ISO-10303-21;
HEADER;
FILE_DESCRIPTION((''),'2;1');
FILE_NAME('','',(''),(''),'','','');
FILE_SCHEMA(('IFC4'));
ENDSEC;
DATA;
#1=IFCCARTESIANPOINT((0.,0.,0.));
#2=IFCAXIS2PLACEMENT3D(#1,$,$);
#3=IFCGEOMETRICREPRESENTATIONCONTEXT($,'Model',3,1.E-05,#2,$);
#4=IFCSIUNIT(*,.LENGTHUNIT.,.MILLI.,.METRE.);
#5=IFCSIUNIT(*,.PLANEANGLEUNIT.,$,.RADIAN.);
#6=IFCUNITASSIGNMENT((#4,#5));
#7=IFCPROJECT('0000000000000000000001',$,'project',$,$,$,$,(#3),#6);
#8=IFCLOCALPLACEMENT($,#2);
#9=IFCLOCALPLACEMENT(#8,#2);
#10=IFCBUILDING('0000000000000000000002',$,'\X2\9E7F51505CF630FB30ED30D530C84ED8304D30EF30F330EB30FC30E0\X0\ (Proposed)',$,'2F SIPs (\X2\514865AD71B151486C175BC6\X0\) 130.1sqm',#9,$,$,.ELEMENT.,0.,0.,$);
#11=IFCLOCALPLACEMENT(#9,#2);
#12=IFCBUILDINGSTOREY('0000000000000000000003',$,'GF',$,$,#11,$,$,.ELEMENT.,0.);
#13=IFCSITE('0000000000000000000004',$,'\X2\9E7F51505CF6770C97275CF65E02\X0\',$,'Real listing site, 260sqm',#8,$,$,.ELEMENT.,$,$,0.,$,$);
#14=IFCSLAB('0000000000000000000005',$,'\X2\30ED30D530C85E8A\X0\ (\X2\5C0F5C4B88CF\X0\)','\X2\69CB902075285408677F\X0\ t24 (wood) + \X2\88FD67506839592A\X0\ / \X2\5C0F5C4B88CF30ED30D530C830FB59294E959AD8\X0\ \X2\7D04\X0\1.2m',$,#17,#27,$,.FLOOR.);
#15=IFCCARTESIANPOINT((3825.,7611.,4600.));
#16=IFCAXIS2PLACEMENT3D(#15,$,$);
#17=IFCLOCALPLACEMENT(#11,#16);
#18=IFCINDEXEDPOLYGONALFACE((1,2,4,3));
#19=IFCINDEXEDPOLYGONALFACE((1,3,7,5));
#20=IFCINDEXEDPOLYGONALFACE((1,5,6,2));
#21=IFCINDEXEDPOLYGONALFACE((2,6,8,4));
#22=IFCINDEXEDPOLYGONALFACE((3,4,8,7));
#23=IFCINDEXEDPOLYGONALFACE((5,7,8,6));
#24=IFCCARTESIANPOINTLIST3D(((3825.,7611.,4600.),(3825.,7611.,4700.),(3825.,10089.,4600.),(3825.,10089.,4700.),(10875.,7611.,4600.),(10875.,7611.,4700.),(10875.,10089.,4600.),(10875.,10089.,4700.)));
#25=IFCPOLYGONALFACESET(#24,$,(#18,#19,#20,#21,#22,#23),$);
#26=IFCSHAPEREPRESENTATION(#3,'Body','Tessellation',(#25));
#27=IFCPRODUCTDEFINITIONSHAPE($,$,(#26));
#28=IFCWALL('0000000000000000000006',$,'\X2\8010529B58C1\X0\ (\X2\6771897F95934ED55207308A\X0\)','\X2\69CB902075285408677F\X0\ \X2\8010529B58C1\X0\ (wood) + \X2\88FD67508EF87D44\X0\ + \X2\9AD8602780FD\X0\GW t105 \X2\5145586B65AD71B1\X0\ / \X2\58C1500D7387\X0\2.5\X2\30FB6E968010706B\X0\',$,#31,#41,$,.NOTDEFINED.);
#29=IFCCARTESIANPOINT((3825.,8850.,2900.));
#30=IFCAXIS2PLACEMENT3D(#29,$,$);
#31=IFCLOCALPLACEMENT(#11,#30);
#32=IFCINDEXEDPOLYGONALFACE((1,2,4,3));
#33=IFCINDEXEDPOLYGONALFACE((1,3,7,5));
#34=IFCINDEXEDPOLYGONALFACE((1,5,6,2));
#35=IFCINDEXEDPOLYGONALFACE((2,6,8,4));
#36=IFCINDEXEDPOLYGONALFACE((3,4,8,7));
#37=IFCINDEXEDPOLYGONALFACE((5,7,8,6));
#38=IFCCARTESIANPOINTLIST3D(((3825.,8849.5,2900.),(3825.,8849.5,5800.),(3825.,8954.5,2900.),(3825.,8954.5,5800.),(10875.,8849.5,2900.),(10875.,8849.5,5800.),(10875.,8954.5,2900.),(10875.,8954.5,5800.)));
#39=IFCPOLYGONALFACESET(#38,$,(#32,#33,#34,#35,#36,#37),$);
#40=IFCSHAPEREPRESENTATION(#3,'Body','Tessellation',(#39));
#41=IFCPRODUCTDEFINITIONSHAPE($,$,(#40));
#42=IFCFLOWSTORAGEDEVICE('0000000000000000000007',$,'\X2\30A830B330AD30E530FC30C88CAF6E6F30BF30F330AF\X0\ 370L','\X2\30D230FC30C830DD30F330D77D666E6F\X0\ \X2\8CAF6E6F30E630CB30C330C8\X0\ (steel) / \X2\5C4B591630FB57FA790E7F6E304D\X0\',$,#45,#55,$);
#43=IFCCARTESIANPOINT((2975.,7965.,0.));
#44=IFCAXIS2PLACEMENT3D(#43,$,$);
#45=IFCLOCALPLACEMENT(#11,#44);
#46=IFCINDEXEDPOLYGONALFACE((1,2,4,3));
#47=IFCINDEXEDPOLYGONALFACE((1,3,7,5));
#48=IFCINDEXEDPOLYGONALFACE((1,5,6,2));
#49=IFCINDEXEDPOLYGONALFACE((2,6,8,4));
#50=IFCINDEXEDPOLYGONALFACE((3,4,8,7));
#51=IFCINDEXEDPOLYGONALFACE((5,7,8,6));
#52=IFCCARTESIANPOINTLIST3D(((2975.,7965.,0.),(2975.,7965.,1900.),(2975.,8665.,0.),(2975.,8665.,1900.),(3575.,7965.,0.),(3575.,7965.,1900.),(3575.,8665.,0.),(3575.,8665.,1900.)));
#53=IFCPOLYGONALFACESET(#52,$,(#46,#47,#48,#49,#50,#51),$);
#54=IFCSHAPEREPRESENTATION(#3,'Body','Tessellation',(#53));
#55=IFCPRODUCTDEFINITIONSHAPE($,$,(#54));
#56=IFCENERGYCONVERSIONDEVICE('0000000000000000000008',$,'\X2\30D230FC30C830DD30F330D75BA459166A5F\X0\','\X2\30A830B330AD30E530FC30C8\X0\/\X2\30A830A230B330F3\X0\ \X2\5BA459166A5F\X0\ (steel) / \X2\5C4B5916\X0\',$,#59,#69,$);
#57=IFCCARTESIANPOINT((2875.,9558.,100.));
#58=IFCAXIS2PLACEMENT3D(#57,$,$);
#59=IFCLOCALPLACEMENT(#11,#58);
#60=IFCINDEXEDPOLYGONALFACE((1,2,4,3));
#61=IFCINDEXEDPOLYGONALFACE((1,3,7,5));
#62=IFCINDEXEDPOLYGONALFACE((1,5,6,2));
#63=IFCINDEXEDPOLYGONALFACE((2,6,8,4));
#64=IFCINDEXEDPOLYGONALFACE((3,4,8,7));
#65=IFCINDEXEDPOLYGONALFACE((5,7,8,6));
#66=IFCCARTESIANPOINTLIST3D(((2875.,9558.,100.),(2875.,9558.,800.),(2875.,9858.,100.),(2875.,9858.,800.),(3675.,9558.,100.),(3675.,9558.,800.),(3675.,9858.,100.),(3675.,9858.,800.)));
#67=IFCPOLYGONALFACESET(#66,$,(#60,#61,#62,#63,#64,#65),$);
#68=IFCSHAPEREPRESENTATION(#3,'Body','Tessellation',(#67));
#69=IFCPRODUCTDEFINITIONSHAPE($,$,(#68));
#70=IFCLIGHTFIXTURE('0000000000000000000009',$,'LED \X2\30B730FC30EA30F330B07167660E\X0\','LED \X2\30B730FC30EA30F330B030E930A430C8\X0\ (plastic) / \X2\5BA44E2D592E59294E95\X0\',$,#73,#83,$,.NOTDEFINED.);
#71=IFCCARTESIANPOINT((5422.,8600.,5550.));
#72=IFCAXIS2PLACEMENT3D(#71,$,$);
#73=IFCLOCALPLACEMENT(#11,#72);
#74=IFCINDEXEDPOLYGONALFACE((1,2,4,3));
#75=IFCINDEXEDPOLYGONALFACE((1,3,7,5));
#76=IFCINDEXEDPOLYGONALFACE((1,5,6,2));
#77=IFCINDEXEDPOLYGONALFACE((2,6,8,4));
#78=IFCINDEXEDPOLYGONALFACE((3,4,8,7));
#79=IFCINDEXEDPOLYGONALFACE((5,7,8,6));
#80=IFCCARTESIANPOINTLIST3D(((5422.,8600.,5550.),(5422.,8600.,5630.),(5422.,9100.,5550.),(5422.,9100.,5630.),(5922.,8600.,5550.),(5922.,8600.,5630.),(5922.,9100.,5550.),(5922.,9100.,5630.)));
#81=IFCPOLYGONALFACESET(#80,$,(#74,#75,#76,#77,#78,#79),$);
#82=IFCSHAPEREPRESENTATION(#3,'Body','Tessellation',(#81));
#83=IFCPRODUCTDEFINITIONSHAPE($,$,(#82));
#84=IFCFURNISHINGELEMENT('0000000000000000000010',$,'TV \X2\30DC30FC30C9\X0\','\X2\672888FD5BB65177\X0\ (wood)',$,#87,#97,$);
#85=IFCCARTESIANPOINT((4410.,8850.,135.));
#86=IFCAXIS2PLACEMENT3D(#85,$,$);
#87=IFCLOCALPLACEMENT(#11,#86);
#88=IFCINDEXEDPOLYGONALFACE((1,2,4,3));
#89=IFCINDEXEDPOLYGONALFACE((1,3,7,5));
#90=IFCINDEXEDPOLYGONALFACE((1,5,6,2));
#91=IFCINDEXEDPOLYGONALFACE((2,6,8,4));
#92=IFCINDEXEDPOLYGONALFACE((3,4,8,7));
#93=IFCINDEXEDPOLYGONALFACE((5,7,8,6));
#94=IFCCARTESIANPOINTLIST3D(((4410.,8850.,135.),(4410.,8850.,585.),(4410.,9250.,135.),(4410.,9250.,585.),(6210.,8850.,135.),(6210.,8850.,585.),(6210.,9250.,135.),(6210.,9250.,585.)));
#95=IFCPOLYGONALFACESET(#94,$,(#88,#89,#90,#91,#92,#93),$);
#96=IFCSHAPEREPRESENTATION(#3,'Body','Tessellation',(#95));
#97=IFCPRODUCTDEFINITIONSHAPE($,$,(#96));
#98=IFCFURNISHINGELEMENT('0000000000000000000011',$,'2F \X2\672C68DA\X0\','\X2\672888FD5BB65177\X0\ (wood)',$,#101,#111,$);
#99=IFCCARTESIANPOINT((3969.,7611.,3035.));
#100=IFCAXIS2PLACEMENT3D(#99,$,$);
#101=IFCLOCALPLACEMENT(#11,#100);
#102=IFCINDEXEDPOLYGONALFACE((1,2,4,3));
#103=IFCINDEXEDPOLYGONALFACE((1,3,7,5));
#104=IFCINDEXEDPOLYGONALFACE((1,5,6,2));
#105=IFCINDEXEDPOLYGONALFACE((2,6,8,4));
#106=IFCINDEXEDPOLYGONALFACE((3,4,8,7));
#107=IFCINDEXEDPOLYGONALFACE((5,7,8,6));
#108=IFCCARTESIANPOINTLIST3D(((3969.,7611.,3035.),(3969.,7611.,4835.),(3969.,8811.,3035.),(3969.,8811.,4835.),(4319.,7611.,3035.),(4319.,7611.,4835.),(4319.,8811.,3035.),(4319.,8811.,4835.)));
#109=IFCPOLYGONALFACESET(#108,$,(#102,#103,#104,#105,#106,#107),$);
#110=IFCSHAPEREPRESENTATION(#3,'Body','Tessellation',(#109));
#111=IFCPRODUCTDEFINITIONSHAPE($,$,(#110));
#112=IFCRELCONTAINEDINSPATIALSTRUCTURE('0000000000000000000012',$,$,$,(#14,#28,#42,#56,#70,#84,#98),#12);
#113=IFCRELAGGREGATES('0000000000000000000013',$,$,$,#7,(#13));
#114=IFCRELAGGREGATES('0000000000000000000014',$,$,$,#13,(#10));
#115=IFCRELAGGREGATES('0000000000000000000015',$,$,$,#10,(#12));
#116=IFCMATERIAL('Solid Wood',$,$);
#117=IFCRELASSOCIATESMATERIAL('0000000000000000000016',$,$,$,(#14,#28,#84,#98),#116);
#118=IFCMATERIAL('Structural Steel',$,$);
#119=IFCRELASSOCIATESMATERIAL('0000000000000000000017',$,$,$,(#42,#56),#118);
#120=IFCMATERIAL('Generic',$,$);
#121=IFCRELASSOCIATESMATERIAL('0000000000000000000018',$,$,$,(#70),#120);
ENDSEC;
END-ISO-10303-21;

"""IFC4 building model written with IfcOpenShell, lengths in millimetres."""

from ifc_helpers import new_model, si_unit, frame, frame_2d, origin, place, context, project, spatial, rectangle, extrude, material, element, save


model = new_model("IFC4")

# Units and contexts
model_context = context("Model", 3, precision=1e-05, world=origin())
ifc_project = project(units=[si_unit("LENGTHUNIT", "METRE", prefix="MILLI"), si_unit("PLANEANGLEUNIT", "RADIAN")], contexts=[model_context])

# Site, building, storey
site_placement = place(None, origin())
site = spatial("IfcSite", under=ifc_project, at=site_placement, Name="鹿児島県霧島市", ObjectType="Real listing site, 260sqm", CompositionType="ELEMENT", RefElevation=0.0)
building_placement = place(site_placement, origin())
building = spatial("IfcBuilding", under=site, at=building_placement, Name="鹿児島・ロフト付きワンルーム (Proposed)", ObjectType="2F SIPs (先断熱先気密) 130.1sqm", CompositionType="ELEMENT", ElevationOfRefHeight=0.0, ElevationOfTerrain=0.0)
storey_placement = place(building_placement, origin())
storey = spatial("IfcBuildingStorey", under=building, at=storey_placement, Name="GF", CompositionType="ELEMENT", Elevation=0.0)

# Shared definitions
ifc_material_1 = material(Name="Solid Wood")

# Slab
slab_placement = place(storey_placement, frame((3825.0, 7611.0, 4600.0)))
element("IfcSlab", 1, at=slab_placement, inside=storey, material=ifc_material_1, Name="ロフト床 (小屋裏)", Description="構造用合板 t24 (wood) + 製材根太 / 小屋裏ロフト・天井高 約1.2m", PredefinedType="FLOOR", context=model_context, shape_type="SweptSolid", body=[
    extrude(rectangle(XDim=7050.0, YDim=2478.0, at=frame_2d((3525.0, 1239.0))), frame((3825.0, 7611.0, 4600.0)), (0.0, 0.0, 1.0), 100.0),
])

# Wall
wall_1_placement = place(storey_placement, frame((3825.0, 8850.0, 2900.0)))
element("IfcWall", 2, at=wall_1_placement, inside=storey, material=ifc_material_1, Name="耐力壁 (東西間仕切り)", Description="構造用合板 耐力壁 (wood) + 製材軸組 + 高性能GW t105 充填断熱 / 壁倍率2.5・準耐火", PredefinedType="NOTDEFINED", context=model_context, shape_type="SweptSolid", body=[
    extrude(rectangle(XDim=7050.0, YDim=105.0, at=frame_2d((3525.0, 52.0))), frame((3825.0, 8850.0, 2900.0)), (0.0, 0.0, 1.0), 2900.0),
])

# Flow storage device
ifc_material_2 = material(Name="Structural Steel")
flow_storage_device_placement = place(storey_placement, frame((2975.0, 7965.0, 0.0)))
element("IfcFlowStorageDevice", 3, at=flow_storage_device_placement, inside=storey, material=ifc_material_2, Name="エコキュート貯湯タンク 370L", Description="ヒートポンプ給湯 貯湯ユニット (steel) / 屋外・基礎置き", context=model_context, shape_type="SweptSolid", body=[
    extrude(rectangle(XDim=600.0, YDim=700.0, at=frame_2d((300.0, 350.0))), frame((2975.0, 7965.0, 0.0)), (0.0, 0.0, 1.0), 1900.0),
])

# Energy conversion device
energy_conversion_device_placement = place(storey_placement, frame((2875.0, 9558.0, 100.0)))
element("IfcEnergyConversionDevice", 4, at=energy_conversion_device_placement, inside=storey, material=ifc_material_2, Name="ヒートポンプ室外機", Description="エコキュート/エアコン 室外機 (steel) / 屋外", context=model_context, shape_type="SweptSolid", body=[
    extrude(rectangle(XDim=800.0, YDim=300.0, at=frame_2d((400.0, 150.0))), frame((2875.0, 9558.0, 100.0)), (0.0, 0.0, 1.0), 700.0),
])

# Light fixture
ifc_material_3 = material(Name="Generic")
light_fixture_placement = place(storey_placement, frame((5422.0, 8600.0, 5550.0)))
element("IfcLightFixture", 5, at=light_fixture_placement, inside=storey, material=ifc_material_3, Name="LED シーリング照明", Description="LED シーリングライト (plastic) / 室中央天井", PredefinedType="NOTDEFINED", context=model_context, shape_type="SweptSolid", body=[
    extrude(rectangle(XDim=500.0, YDim=500.0, at=frame_2d((250.0, 250.0))), frame((5422.0, 8600.0, 5550.0)), (0.0, 0.0, 1.0), 80.0),
])

# Furnishing elements
furnishing_1_placement = place(storey_placement, frame((4410.0, 8850.0, 135.0)))
element("IfcFurnishingElement", 6, at=furnishing_1_placement, inside=storey, material=ifc_material_1, Name="TV ボード", Description="木製家具 (wood)", context=model_context, shape_type="SweptSolid", body=[
    extrude(rectangle(XDim=1800.0, YDim=400.0, at=frame_2d((900.0, 200.0))), frame((4410.0, 8850.0, 135.0)), (0.0, 0.0, 1.0), 450.0),
])
furnishing_2_placement = place(storey_placement, frame((3969.0, 7611.0, 3035.0)))
element("IfcFurnishingElement", 7, at=furnishing_2_placement, inside=storey, material=ifc_material_1, Name="2F 本棚", Description="木製家具 (wood)", context=model_context, shape_type="SweptSolid", body=[
    extrude(rectangle(XDim=350.0, YDim=1200.0, at=frame_2d((175.0, 600.0))), frame((3969.0, 7611.0, 3035.0)), (0.0, 0.0, 1.0), 1800.0),
])

save(model, "model.ifc")
